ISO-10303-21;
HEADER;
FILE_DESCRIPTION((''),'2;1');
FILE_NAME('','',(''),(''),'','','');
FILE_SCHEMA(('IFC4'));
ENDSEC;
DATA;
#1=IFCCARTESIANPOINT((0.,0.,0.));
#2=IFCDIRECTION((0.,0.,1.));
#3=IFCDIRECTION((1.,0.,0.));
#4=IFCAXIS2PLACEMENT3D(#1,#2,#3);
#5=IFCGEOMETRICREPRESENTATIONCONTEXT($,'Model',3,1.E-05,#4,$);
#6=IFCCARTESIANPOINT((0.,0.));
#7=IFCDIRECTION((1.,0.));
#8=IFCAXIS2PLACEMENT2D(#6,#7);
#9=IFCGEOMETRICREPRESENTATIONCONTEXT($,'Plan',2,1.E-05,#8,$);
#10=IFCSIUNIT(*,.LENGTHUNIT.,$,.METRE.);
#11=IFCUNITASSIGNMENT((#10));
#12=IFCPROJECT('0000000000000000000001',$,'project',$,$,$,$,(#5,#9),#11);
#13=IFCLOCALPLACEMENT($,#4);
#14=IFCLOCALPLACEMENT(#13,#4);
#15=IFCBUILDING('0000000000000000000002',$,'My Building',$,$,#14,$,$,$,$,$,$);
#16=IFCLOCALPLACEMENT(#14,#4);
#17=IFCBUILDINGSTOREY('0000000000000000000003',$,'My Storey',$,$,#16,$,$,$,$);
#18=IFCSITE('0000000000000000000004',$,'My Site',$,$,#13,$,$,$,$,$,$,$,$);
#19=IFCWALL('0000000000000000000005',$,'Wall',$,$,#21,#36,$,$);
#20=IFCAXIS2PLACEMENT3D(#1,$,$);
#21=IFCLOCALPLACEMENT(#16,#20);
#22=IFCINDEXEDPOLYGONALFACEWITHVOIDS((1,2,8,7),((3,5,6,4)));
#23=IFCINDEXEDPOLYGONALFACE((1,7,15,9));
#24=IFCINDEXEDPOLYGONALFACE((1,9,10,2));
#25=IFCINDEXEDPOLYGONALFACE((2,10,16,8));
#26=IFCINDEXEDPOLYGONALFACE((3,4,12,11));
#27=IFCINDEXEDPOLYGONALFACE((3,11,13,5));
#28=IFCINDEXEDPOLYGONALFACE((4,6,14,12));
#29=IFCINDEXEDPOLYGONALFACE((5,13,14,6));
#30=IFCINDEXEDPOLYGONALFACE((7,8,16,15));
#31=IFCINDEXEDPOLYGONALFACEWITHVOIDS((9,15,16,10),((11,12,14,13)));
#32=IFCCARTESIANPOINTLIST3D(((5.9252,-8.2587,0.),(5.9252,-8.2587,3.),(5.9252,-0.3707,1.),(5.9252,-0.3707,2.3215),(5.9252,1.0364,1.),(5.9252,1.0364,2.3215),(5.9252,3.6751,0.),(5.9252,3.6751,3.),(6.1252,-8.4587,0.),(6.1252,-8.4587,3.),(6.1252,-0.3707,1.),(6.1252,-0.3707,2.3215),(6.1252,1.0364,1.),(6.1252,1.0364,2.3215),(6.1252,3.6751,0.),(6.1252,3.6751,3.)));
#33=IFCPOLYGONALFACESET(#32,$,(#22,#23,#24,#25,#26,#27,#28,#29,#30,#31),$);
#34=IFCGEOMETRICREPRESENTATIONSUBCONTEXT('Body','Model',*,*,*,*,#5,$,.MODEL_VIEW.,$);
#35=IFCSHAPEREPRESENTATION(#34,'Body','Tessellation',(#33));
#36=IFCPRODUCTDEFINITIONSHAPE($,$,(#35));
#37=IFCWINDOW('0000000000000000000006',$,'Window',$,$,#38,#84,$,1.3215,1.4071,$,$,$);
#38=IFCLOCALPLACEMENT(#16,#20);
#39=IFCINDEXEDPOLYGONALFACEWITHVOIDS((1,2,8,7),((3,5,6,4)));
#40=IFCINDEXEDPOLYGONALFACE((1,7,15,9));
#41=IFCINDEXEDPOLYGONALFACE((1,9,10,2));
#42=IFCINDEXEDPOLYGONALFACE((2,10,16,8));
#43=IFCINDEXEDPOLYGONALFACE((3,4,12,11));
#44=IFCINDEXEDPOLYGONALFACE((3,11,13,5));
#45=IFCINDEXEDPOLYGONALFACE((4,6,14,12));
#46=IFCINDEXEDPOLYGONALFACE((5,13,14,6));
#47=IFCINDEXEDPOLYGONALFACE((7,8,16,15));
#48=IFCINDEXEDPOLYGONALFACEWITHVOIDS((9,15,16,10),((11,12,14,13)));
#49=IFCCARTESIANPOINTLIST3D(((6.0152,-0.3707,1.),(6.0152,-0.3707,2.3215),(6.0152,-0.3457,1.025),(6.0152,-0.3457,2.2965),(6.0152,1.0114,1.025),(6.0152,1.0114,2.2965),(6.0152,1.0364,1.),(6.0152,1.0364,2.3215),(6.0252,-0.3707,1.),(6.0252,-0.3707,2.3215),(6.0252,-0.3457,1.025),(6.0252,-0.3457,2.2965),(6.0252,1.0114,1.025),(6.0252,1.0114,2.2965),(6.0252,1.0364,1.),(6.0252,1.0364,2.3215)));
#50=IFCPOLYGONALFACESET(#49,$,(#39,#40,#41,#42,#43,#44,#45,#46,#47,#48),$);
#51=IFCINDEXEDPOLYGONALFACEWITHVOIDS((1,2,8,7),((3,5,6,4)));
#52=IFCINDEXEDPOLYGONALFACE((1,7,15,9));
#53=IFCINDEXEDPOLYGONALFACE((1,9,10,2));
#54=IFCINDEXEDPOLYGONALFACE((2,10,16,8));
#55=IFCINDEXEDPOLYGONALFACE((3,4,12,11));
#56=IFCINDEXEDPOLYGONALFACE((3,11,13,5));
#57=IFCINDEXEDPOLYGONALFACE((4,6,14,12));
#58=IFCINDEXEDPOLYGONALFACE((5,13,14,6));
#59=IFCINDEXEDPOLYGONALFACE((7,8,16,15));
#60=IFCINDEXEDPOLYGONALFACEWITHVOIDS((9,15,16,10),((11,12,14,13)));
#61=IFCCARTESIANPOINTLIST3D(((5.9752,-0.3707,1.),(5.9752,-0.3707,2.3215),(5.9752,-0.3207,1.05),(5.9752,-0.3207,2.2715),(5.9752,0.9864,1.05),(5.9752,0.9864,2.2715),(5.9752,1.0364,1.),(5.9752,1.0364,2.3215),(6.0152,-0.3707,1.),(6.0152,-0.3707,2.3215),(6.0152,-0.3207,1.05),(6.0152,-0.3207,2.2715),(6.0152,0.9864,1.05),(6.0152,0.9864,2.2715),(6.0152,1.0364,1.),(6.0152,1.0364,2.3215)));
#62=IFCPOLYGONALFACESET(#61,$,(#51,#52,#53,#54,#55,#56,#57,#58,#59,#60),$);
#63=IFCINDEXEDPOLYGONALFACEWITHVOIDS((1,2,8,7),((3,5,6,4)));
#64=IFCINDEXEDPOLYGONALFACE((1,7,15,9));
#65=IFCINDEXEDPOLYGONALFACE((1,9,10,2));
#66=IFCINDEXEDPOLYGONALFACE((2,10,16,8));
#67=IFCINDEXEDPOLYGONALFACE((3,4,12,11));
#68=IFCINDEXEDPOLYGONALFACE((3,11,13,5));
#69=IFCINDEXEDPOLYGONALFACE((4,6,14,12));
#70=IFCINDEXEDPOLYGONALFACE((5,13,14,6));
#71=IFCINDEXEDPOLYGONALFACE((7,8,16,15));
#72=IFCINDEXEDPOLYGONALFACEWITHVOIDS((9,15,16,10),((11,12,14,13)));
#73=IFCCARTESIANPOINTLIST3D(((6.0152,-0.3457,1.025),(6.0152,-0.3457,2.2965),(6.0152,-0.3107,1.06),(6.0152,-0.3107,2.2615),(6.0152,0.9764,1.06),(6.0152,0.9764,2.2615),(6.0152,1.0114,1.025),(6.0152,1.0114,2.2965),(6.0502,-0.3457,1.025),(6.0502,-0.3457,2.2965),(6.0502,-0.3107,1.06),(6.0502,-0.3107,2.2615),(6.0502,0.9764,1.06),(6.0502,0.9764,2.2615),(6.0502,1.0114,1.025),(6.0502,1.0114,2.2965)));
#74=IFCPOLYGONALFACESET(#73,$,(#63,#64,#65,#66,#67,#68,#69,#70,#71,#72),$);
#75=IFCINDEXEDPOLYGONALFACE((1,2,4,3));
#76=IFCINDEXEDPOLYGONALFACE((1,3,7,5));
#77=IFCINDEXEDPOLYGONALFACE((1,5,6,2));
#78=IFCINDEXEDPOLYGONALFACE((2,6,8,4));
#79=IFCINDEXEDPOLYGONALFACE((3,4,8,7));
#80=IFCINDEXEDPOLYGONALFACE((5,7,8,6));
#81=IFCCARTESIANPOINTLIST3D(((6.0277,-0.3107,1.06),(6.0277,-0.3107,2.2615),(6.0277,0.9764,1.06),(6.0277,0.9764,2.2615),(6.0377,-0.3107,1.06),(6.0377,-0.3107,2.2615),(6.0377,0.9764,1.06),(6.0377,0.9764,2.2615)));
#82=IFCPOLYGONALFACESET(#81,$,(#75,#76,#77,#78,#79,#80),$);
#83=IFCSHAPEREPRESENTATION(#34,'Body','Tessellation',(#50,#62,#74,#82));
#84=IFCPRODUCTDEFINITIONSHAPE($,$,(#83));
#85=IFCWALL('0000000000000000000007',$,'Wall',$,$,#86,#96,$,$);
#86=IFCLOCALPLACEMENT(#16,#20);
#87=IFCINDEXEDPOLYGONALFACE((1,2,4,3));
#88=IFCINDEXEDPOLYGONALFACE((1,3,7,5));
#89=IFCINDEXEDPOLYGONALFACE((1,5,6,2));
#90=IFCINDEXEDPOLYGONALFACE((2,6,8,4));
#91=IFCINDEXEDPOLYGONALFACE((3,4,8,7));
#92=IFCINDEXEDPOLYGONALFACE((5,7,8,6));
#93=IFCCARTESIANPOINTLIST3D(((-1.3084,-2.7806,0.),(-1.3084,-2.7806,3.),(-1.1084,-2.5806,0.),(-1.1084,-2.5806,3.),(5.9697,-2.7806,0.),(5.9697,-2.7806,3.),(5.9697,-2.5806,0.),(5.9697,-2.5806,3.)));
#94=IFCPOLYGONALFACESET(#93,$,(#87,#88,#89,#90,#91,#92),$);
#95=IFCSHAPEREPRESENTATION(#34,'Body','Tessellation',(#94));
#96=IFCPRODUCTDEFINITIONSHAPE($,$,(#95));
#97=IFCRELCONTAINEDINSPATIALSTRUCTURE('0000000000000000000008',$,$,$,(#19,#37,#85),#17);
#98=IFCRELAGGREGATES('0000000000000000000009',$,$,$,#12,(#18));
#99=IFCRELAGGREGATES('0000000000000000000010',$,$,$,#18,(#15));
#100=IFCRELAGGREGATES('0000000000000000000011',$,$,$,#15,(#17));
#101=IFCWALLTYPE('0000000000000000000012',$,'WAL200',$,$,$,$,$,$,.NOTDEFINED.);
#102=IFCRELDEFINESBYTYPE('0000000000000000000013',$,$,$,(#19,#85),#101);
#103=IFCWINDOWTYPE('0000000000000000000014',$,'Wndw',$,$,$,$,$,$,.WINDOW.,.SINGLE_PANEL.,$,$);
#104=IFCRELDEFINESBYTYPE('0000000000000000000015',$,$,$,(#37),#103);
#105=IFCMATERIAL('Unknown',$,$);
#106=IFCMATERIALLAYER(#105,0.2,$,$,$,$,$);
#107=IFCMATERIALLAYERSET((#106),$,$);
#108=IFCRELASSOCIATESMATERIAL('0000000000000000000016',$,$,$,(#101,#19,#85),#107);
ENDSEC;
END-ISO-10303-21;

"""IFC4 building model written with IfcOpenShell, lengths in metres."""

from ifc_helpers import new_model, entity, si_unit, frame, origin_with_axes, origin_2d_with_axis, place, context, subcontext, project, spatial, line, indexed_curve, outline, extrude, shape, source, transform, mapped, material, layer, layer_set, layer_usage, type_object, type_shapes, element, fill, save


model = new_model("IFC4")

# Units and contexts
model_context = context("Model", 3, precision=1e-05, world=origin_with_axes())
plan_context = context("Plan", 2, precision=1e-05, world=origin_2d_with_axis())
body_context_1 = subcontext(model_context, "Body", "Model", "MODEL_VIEW")
body_context_2 = subcontext(plan_context, "Body", "Plan", "PLAN_VIEW")
ifc_project = project(units=[si_unit("LENGTHUNIT", "METRE")], contexts=[model_context, plan_context])

# Site, building, storey
site_placement = place(None, origin_with_axes())
site = spatial("IfcSite", under=ifc_project, at=site_placement, Name="My Site")
building_placement = place(site_placement, origin_with_axes())
building = spatial("IfcBuilding", under=site, at=building_placement, Name="My Building")
storey_placement = place(building_placement, origin_with_axes())
storey = spatial("IfcBuildingStorey", under=building, at=storey_placement, Name="My Storey")

# Wall, opening, window
ifc_material = material(Name="Unknown")
ifc_layer = layer(ifc_material, 0.2)
ifc_layer_set = layer_set([ifc_layer])
ifc_layer_usage_1 = layer_usage(ifc_layer_set, "AXIS2", "POSITIVE", 0.0)
wall_type = type_object("IfcWallType", Name="WAL200", PredefinedType="NOTDEFINED", material=ifc_layer_set)
wall_1_placement = place(storey_placement, frame((6.1252, -8.4587, 0.0), z_axis=(0.0, 0.0, 1.0), x_axis=(0.0, 1.0, 0.0)))
wall_1 = element("IfcWall", 1, at=wall_1_placement, inside=storey, type_object=wall_type, material=ifc_layer_usage_1, Name="Wall", context=body_context_1, shape_type="SweptSolid", body=[
    extrude(outline(indexed_curve([(0.0, 0.0), (0.2, 0.2), (12.1338, 0.2), (12.1338, 0.0)], segments=[line(1, 2, 3, 4, 1)])), origin_with_axes(), (0.0, 0.0, 1.0), 3.0),
])
shared_shape_1 = source(origin_with_axes(), body_context_1, "Body", "SweptSolid", [
    extrude(outline(indexed_curve([(0.0, 0.0), (1.4071, 0.0), (1.4071, 1.3215), (0.0, 1.3215)], segments=[line(1, 2, 3, 4, 1)])), frame((0.0, -0.6, 0.0), z_axis=(0.0, -1.0, 0.0), x_axis=(1.0, 0.0, 0.0)), (0.0, 0.0, -1.0), 1.2),
])
opening_1_placement = place(wall_1_placement, frame((9.4951, 0.2, 1.0), z_axis=(0.0, 0.0, 1.0), x_axis=(-1.0, 0.0, 0.0)))
opening_1 = element("IfcOpeningElement", 2, at=opening_1_placement, cuts=wall_1, PredefinedType="OPENING", context=body_context_1, shape_type="MappedRepresentation", body=[
    mapped(shared_shape_1, transform((0.0, 0.0, 0.0), x_axis=(1.0, 0.0, 0.0), y_axis=(0.0, 1.0, 0.0), z_axis=(0.0, 0.0, 1.0), scale=1.0)),
])
window_type = type_object("IfcWindowType", Name="Wndw", PartitioningType="SINGLE_PANEL", PredefinedType="WINDOW")
shared_shape_2 = source(origin_with_axes(), body_context_1, "Body", "SweptSolid", [
    extrude(outline(indexed_curve([(0.0, 0.0), (1.4071, 0.0), (1.4071, 1.3215), (0.0, 1.3215)], segments=[line(1, 2, 3, 4, 1)]), holes=[indexed_curve([(0.025, 0.025), (1.3821, 0.025), (1.3821, 1.2965), (0.025, 1.2965)], segments=[line(1, 2, 3, 4, 1)])]), frame((0.0, 0.09, 0.0), z_axis=(0.0, -1.0, 0.0), x_axis=(1.0, 0.0, 0.0)), (0.0, 0.0, -1.0), 0.01),
    extrude(outline(indexed_curve([(0.0, 0.0), (1.4071, 0.0), (1.4071, 1.3215), (0.0, 1.3215)], segments=[line(1, 2, 3, 4, 1)]), holes=[indexed_curve([(0.05, 0.05), (1.3571, 0.05), (1.3571, 1.2715), (0.05, 1.2715)], segments=[line(1, 2, 3, 4, 1)])]), frame((0.0, 0.05, 0.0), z_axis=(0.0, -1.0, 0.0), x_axis=(1.0, 0.0, 0.0)), (0.0, 0.0, -1.0), 0.04),
    extrude(outline(indexed_curve([(0.0, 0.0), (1.3571, 0.0), (1.3571, 1.2715), (0.0, 1.2715)], segments=[line(1, 2, 3, 4, 1)]), holes=[indexed_curve([(0.035, 0.035), (1.3221, 0.035), (1.3221, 1.2365), (0.035, 1.2365)], segments=[line(1, 2, 3, 4, 1)])]), frame((0.025, 0.09, 0.025), z_axis=(0.0, -1.0, 0.0), x_axis=(1.0, 0.0, 0.0)), (0.0, 0.0, -1.0), 0.035),
    extrude(outline(indexed_curve([(0.035, 0.035), (1.3221, 0.035), (1.3221, 1.2365), (0.035, 1.2365)], segments=[line(1, 2, 3, 4, 1)])), frame((0.025, 0.1025, 0.025), z_axis=(0.0, -1.0, 0.0), x_axis=(1.0, 0.0, 0.0)), (0.0, 0.0, -1.0), 0.01),
])
shared_shape_3 = source(origin_with_axes(), body_context_2, "Body", "Curve2D", [
    entity("IfcIndexedPolyCurve", entity("IfcCartesianPointList2D", [[0.05, 0.05], [1.3571, 0.05]])),
    entity("IfcIndexedPolyCurve", entity("IfcCartesianPointList2D", [[0.0, 0.1], [0.025, 0.1], [0.025, 0.09], [0.05, 0.09], [0.05, 0.05], [0.0, 0.05]]), [entity("IfcLineIndex", [1, 2, 3, 4, 5, 6, 1])]),
    entity("IfcIndexedPolyCurve", entity("IfcCartesianPointList2D", [[1.4071, 0.1], [1.3821, 0.1], [1.3821, 0.09], [1.3571, 0.09], [1.3571, 0.05], [1.4071, 0.05]]), [entity("IfcLineIndex", [1, 2, 3, 4, 5, 6, 1])]),
    entity("IfcIndexedPolyCurve", entity("IfcCartesianPointList2D", [[0.025, 0.09], [0.06, 0.09], [0.06, 0.125], [0.025, 0.125]]), [entity("IfcLineIndex", [1, 2, 3, 4, 1])]),
    entity("IfcIndexedPolyCurve", entity("IfcCartesianPointList2D", [[1.3821, 0.09], [1.3471, 0.09], [1.3471, 0.125], [1.3821, 0.125]]), [entity("IfcLineIndex", [1, 2, 3, 4, 1])]),
    entity("IfcIndexedPolyCurve", entity("IfcCartesianPointList2D", [[0.06, 0.09], [1.3471, 0.09]])),
    entity("IfcIndexedPolyCurve", entity("IfcCartesianPointList2D", [[0.06, 0.125], [1.3471, 0.125]])),
    entity("IfcIndexedPolyCurve", entity("IfcCartesianPointList2D", [[0.06, 0.1075], [1.3471, 0.1075]])),
])
type_shapes(window_type, [shared_shape_2, shared_shape_3])
window_1_placement = place(opening_1_placement, frame((0.0, 0.0, 0.0), z_axis=(0.0, 0.0, 1.0), x_axis=(1.0, 0.0, 0.0)))
window_1 = element("IfcWindow", 3, at=window_1_placement, inside=storey, type_object=window_type, Name="Window", OverallHeight=1.3215, OverallWidth=1.4071, shapes=[
    shape(body_context_1, "Body", "MappedRepresentation", [mapped(shared_shape_2, transform((0.0, 0.0, 0.0), x_axis=(1.0, 0.0, 0.0), y_axis=(0.0, 1.0, 0.0), z_axis=(0.0, 0.0, 1.0), scale=1.0))]),
    shape(body_context_2, "Body", "MappedRepresentation", [mapped(shared_shape_3, transform((0.0, 0.0, 0.0), x_axis=(1.0, 0.0, 0.0), y_axis=(0.0, 1.0, 0.0), z_axis=(0.0, 0.0, 1.0), scale=1.0))]),
])
fill(opening_1, window_1)

# Wall
ifc_layer_usage_2 = layer_usage(ifc_layer_set, "AXIS2", "POSITIVE", 0.0)
wall_2_placement = place(storey_placement, frame((-1.3084, -2.7806, 0.0), z_axis=(0.0, 0.0, 1.0), x_axis=(1.0, 0.0, 0.0)))
element("IfcWall", 4, at=wall_2_placement, inside=storey, type_object=wall_type, material=ifc_layer_usage_2, Name="Wall", context=body_context_1, shape_type="SweptSolid", body=[
    extrude(outline(indexed_curve([(0.0, 0.0), (0.2, 0.2), (7.2781, 0.2), (7.2781, 0.0)], segments=[line(1, 2, 3, 4, 1)])), origin_with_axes(), (0.0, 0.0, 1.0), 3.0),
])

save(model, "model.ifc")
